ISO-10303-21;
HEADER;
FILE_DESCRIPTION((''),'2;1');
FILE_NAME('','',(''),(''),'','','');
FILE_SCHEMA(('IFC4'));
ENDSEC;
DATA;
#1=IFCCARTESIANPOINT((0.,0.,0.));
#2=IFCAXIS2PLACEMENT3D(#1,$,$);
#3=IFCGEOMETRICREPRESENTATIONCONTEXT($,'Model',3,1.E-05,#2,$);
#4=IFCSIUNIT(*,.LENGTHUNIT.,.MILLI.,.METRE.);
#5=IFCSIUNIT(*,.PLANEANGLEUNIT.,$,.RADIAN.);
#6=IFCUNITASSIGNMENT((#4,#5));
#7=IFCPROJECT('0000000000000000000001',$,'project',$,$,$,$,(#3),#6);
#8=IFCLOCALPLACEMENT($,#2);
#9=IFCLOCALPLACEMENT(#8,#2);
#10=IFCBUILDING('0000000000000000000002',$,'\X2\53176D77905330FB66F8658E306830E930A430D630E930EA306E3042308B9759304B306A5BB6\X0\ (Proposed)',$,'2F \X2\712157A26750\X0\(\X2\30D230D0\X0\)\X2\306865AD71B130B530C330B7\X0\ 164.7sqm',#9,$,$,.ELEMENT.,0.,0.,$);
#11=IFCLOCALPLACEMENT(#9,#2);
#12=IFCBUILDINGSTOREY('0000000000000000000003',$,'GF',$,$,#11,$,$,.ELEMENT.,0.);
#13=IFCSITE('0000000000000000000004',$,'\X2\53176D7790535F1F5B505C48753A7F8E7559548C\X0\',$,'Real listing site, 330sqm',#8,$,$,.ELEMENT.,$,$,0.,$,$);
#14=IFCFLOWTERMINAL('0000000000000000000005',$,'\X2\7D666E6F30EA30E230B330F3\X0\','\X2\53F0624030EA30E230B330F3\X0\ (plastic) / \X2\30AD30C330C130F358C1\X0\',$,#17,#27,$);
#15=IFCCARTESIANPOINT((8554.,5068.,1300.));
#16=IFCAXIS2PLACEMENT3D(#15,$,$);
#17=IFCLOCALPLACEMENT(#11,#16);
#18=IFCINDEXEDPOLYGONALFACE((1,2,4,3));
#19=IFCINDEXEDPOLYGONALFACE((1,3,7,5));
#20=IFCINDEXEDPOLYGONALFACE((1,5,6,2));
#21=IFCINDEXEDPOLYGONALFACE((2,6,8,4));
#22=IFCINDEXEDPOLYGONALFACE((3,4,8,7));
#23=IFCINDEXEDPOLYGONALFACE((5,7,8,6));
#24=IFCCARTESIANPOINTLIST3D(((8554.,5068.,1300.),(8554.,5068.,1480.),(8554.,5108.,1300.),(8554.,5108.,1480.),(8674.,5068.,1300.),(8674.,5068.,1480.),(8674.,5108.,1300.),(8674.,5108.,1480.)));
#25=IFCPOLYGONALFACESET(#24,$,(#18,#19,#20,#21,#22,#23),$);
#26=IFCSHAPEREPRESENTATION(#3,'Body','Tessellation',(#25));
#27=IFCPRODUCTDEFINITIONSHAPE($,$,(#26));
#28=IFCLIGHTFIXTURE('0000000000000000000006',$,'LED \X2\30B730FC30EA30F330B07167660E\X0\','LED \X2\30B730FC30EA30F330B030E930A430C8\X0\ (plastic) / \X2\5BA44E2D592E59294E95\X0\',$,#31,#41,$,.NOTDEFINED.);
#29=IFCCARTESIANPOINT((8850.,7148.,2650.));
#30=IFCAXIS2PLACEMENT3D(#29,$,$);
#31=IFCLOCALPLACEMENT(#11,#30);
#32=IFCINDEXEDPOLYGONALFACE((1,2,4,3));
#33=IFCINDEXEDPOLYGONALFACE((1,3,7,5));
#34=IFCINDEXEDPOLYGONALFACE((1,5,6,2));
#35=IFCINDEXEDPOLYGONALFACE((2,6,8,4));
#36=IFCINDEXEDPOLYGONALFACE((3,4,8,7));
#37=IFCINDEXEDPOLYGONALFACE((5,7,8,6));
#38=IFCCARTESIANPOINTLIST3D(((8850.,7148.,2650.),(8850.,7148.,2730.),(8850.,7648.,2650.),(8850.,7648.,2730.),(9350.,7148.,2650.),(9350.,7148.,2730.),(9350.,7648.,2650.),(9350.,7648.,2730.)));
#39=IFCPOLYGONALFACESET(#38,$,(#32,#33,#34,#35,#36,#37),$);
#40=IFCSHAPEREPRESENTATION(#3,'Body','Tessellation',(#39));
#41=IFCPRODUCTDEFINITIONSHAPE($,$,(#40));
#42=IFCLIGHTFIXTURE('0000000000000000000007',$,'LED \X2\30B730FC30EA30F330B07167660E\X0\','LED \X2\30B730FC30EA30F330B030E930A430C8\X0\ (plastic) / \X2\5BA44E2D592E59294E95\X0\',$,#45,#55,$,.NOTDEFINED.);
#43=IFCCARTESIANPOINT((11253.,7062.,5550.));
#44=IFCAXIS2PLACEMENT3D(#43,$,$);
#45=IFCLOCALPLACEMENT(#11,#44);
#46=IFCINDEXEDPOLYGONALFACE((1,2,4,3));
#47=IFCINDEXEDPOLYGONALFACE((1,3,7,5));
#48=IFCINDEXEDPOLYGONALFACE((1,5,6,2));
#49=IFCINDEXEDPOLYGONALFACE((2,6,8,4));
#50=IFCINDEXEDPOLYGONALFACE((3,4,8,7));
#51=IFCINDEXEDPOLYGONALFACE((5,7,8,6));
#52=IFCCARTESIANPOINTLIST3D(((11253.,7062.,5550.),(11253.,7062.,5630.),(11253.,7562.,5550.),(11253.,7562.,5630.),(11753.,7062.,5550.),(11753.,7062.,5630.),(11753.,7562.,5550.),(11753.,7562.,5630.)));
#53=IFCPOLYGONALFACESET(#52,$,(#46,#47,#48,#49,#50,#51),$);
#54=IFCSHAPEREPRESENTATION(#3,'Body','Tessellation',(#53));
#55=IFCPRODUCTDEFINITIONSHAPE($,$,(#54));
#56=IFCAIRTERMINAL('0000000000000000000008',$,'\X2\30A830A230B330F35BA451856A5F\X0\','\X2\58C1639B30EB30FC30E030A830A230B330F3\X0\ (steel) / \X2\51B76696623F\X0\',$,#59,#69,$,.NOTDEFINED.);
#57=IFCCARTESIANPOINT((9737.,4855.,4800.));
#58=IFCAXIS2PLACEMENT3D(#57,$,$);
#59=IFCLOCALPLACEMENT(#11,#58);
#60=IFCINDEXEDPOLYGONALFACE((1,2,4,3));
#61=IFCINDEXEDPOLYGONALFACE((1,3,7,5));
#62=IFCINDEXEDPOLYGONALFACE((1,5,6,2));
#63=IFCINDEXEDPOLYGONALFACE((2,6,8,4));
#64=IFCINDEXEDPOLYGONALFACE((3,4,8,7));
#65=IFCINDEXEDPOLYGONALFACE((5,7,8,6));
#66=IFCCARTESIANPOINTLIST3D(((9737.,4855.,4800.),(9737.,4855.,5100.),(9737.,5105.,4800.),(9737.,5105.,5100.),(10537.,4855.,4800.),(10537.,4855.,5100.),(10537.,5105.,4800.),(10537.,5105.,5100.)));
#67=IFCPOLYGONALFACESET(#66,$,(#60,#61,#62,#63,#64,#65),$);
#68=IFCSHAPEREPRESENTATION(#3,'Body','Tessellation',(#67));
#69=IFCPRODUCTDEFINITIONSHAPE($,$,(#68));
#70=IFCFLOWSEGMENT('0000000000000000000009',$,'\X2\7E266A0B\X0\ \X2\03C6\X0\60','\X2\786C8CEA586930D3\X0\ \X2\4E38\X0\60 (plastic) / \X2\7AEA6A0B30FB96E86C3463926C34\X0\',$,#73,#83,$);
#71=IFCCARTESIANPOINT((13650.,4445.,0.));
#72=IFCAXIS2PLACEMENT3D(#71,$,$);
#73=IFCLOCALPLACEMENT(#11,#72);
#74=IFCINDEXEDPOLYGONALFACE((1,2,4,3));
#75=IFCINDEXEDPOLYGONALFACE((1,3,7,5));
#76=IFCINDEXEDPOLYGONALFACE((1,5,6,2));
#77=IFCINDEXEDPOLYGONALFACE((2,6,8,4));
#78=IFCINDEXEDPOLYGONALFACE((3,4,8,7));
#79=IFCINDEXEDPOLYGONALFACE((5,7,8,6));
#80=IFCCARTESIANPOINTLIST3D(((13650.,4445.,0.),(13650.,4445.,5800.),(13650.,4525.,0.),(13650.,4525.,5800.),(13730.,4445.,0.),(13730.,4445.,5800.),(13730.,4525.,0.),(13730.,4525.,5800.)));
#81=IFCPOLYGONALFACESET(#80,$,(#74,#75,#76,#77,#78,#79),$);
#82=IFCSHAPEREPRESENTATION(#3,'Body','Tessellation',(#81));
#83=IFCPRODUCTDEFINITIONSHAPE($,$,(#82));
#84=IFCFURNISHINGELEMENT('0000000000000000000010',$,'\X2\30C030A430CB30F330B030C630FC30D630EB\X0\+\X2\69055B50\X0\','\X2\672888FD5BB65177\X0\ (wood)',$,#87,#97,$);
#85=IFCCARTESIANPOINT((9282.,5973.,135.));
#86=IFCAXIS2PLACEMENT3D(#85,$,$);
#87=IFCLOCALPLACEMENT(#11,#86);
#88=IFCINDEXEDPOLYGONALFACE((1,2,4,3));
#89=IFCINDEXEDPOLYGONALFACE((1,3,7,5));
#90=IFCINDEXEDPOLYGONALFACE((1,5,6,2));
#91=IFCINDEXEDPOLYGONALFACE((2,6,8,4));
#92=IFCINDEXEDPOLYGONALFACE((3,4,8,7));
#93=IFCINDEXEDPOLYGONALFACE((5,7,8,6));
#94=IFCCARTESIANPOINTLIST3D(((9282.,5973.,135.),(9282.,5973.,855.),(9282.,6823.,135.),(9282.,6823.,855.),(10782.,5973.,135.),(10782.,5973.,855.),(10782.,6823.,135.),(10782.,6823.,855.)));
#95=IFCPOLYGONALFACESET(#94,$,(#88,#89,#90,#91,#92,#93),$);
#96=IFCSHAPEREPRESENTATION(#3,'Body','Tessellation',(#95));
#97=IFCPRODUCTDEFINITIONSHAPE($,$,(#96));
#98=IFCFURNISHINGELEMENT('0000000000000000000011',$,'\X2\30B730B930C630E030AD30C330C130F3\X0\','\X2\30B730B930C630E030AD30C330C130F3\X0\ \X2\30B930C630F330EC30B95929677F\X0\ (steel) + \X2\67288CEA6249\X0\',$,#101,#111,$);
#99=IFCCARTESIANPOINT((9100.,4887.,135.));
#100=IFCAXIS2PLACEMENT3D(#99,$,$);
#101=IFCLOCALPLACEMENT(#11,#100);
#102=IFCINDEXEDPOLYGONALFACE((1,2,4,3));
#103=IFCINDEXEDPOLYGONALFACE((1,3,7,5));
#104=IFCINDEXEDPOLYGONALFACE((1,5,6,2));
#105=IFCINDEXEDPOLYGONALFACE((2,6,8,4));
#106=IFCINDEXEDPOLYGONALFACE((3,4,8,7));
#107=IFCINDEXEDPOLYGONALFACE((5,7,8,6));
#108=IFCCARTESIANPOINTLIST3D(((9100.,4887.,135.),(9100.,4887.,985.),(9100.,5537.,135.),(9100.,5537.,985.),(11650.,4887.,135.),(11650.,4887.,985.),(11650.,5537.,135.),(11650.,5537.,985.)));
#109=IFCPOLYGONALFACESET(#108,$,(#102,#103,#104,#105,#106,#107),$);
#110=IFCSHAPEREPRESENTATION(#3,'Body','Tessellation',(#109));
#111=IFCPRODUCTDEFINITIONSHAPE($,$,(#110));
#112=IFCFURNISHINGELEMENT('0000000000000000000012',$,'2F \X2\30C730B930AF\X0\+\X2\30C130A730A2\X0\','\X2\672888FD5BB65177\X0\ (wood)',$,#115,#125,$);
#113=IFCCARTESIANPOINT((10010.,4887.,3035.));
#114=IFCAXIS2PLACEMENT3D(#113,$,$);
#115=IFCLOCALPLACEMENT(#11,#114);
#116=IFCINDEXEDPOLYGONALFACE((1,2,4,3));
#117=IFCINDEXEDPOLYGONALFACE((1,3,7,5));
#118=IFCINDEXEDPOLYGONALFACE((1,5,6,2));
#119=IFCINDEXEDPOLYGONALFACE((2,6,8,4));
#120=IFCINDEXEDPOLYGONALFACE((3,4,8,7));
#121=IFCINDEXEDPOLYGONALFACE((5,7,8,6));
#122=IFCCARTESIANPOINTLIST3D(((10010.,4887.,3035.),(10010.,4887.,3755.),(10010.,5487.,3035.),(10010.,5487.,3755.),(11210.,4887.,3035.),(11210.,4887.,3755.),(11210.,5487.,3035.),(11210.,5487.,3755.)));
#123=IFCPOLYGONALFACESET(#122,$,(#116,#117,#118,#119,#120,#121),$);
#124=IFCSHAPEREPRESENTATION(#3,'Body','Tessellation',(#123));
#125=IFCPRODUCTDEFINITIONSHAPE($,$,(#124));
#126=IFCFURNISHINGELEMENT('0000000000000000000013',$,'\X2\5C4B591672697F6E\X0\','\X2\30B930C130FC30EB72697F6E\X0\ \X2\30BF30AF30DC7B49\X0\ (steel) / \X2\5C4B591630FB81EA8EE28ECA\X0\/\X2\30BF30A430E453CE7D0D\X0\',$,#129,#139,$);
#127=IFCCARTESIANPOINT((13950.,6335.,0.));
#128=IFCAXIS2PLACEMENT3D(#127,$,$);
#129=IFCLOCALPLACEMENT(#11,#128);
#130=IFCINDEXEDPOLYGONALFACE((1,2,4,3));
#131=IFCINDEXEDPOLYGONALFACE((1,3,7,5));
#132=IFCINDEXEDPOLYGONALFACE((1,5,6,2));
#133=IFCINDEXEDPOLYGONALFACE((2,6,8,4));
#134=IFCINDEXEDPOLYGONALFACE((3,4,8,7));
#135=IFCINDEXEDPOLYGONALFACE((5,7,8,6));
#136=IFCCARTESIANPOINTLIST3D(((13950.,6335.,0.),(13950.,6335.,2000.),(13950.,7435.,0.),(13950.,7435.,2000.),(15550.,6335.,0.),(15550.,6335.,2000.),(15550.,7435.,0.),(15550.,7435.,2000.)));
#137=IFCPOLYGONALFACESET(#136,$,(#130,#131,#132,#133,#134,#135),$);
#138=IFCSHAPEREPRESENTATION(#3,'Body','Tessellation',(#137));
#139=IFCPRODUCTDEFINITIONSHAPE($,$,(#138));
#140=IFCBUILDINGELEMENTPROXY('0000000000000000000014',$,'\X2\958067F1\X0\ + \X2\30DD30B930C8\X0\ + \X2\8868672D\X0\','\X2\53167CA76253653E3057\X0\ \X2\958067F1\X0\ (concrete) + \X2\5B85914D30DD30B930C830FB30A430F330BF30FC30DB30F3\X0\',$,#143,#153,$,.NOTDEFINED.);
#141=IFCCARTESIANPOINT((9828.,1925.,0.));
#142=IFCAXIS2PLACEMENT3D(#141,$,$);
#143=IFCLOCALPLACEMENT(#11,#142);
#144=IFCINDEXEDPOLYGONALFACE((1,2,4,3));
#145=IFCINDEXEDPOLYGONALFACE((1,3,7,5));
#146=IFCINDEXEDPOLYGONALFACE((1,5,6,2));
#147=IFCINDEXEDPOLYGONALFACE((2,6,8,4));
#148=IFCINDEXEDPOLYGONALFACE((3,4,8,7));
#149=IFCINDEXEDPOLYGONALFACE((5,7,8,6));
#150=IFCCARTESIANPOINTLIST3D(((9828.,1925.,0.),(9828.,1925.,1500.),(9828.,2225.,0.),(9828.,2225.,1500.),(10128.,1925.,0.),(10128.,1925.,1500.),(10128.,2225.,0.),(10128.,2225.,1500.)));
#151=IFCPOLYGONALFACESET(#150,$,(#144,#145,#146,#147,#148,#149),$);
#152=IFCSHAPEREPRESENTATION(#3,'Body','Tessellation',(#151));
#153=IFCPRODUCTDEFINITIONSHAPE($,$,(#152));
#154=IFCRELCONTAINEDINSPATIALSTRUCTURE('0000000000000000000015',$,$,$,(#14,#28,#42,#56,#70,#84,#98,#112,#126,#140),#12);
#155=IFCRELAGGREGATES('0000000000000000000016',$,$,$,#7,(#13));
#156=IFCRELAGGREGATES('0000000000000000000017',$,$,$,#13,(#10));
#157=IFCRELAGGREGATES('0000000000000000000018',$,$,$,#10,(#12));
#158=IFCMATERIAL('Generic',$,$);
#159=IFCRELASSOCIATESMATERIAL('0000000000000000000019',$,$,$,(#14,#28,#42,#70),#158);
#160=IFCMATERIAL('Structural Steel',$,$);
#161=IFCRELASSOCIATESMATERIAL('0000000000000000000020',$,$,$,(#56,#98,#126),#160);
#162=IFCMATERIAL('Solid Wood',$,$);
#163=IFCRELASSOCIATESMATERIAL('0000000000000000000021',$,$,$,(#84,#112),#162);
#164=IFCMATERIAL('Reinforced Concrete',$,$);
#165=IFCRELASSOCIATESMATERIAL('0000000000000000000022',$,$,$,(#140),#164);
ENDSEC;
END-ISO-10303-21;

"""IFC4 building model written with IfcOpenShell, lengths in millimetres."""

from ifc_helpers import new_model, si_unit, frame, frame_2d, origin, place, context, project, spatial, rectangle, extrude, material, element, save


model = new_model("IFC4")

# Units and contexts
model_context = context("Model", 3, precision=1e-05, world=origin())
ifc_project = project(units=[si_unit("LENGTHUNIT", "METRE", prefix="MILLI"), si_unit("PLANEANGLEUNIT", "RADIAN")], contexts=[model_context])

# Site, building, storey
site_placement = place(None, origin())
site = spatial("IfcSite", under=ifc_project, at=site_placement, Name="北海道弟子屈町美留和", ObjectType="Real listing site, 330sqm", CompositionType="ELEMENT", RefElevation=0.0)
building_placement = place(site_placement, origin())
building = spatial("IfcBuilding", under=site, at=building_placement, Name="北海道・書斎とライブラリのある静かな家 (Proposed)", ObjectType="2F 無垢材(ヒバ)と断熱サッシ 164.7sqm", CompositionType="ELEMENT", ElevationOfRefHeight=0.0, ElevationOfTerrain=0.0)
storey_placement = place(building_placement, origin())
storey = spatial("IfcBuildingStorey", under=building, at=storey_placement, Name="GF", CompositionType="ELEMENT", Elevation=0.0)

# Shared definitions
ifc_material_1 = material(Name="Solid Wood")

# Shared definitions
ifc_material_2 = material(Name="Reinforced Concrete")

# Shared definitions
ifc_material_3 = material(Name="Structural Steel")

# Flow terminal
ifc_material_4 = material(Name="Generic")
flow_terminal_1_placement = place(storey_placement, frame((8554.0, 5068.0, 1300.0)))
element("IfcFlowTerminal", 1, at=flow_terminal_1_placement, inside=storey, material=ifc_material_4, Name="給湯リモコン", Description="台所リモコン (plastic) / キッチン壁", context=model_context, shape_type="SweptSolid", body=[
    extrude(rectangle(XDim=120.0, YDim=40.0, at=frame_2d((60.0, 20.0))), frame((8554.0, 5068.0, 1300.0)), (0.0, 0.0, 1.0), 180.0),
])

# Light fixtures
light_fixture_1_placement = place(storey_placement, frame((8850.0, 7148.0, 2650.0)))
element("IfcLightFixture", 2, at=light_fixture_1_placement, inside=storey, material=ifc_material_4, Name="LED シーリング照明", Description="LED シーリングライト (plastic) / 室中央天井", PredefinedType="NOTDEFINED", context=model_context, shape_type="SweptSolid", body=[
    extrude(rectangle(XDim=500.0, YDim=500.0, at=frame_2d((250.0, 250.0))), frame((8850.0, 7148.0, 2650.0)), (0.0, 0.0, 1.0), 80.0),
])
light_fixture_2_placement = place(storey_placement, frame((11253.0, 7062.0, 5550.0)))
element("IfcLightFixture", 3, at=light_fixture_2_placement, inside=storey, material=ifc_material_4, Name="LED シーリング照明", Description="LED シーリングライト (plastic) / 室中央天井", PredefinedType="NOTDEFINED", context=model_context, shape_type="SweptSolid", body=[
    extrude(rectangle(XDim=500.0, YDim=500.0, at=frame_2d((250.0, 250.0))), frame((11253.0, 7062.0, 5550.0)), (0.0, 0.0, 1.0), 80.0),
])

# Air terminal
air_terminal_placement = place(storey_placement, frame((9737.0, 4855.0, 4800.0)))
element("IfcAirTerminal", 4, at=air_terminal_placement, inside=storey, material=ifc_material_3, Name="エアコン室内機", Description="壁掛ルームエアコン (steel) / 冷暖房", PredefinedType="NOTDEFINED", context=model_context, shape_type="SweptSolid", body=[
    extrude(rectangle(XDim=800.0, YDim=250.0, at=frame_2d((400.0, 125.0))), frame((9737.0, 4855.0, 4800.0)), (0.0, 0.0, 1.0), 300.0),
])

# Flow segment
flow_segment_placement = place(storey_placement, frame((13650.0, 4445.0, 0.0)))
element("IfcFlowSegment", 5, at=flow_segment_placement, inside=storey, material=ifc_material_4, Name="縦樋 φ60", Description="硬質塩ビ 丸60 (plastic) / 竪樋・雨水排水", context=model_context, shape_type="SweptSolid", body=[
    extrude(rectangle(XDim=80.0, YDim=80.0, at=frame_2d((40.0, 40.0))), frame((13650.0, 4445.0, 0.0)), (0.0, 0.0, 1.0), 5800.0),
])

# Furnishing elements
furnishing_1_placement = place(storey_placement, frame((9282.0, 5973.0, 135.0)))
element("IfcFurnishingElement", 6, at=furnishing_1_placement, inside=storey, material=ifc_material_1, Name="ダイニングテーブル+椅子", Description="木製家具 (wood)", context=model_context, shape_type="SweptSolid", body=[
    extrude(rectangle(XDim=1500.0, YDim=850.0, at=frame_2d((750.0, 425.0))), frame((9282.0, 5973.0, 135.0)), (0.0, 0.0, 1.0), 720.0),
])
furnishing_2_placement = place(storey_placement, frame((9100.0, 4887.0, 135.0)))
element("IfcFurnishingElement", 7, at=furnishing_2_placement, inside=storey, material=ifc_material_3, Name="システムキッチン", Description="システムキッチン ステンレス天板 (steel) + 木質扉", context=model_context, shape_type="SweptSolid", body=[
    extrude(rectangle(XDim=2550.0, YDim=650.0, at=frame_2d((1275.0, 325.0))), frame((9100.0, 4887.0, 135.0)), (0.0, 0.0, 1.0), 850.0),
])
furnishing_3_placement = place(storey_placement, frame((10010.0, 4887.0, 3035.0)))
element("IfcFurnishingElement", 8, at=furnishing_3_placement, inside=storey, material=ifc_material_1, Name="2F デスク+チェア", Description="木製家具 (wood)", context=model_context, shape_type="SweptSolid", body=[
    extrude(rectangle(XDim=1200.0, YDim=600.0, at=frame_2d((600.0, 300.0))), frame((10010.0, 4887.0, 3035.0)), (0.0, 0.0, 1.0), 720.0),
])
furnishing_4_placement = place(storey_placement, frame((13950.0, 6335.0, 0.0)))
element("IfcFurnishingElement", 9, at=furnishing_4_placement, inside=storey, material=ifc_material_3, Name="屋外物置", Description="スチール物置 タクボ等 (steel) / 屋外・自転車/タイヤ収納", context=model_context, shape_type="SweptSolid", body=[
    extrude(rectangle(XDim=1600.0, YDim=1100.0, at=frame_2d((800.0, 550.0))), frame((13950.0, 6335.0, 0.0)), (0.0, 0.0, 1.0), 2000.0),
])

# Building element proxy
proxy_placement = place(storey_placement, frame((9828.0, 1925.0, 0.0)))
element("IfcBuildingElementProxy", 10, at=proxy_placement, inside=storey, material=ifc_material_2, Name="門柱 + ポスト + 表札", Description="化粧打放し 門柱 (concrete) + 宅配ポスト・インターホン", PredefinedType="NOTDEFINED", context=model_context, shape_type="SweptSolid", body=[
    extrude(rectangle(XDim=300.0, YDim=300.0, at=frame_2d((150.0, 150.0))), frame((9828.0, 1925.0, 0.0)), (0.0, 0.0, 1.0), 1500.0),
])

save(model, "model.ifc")
